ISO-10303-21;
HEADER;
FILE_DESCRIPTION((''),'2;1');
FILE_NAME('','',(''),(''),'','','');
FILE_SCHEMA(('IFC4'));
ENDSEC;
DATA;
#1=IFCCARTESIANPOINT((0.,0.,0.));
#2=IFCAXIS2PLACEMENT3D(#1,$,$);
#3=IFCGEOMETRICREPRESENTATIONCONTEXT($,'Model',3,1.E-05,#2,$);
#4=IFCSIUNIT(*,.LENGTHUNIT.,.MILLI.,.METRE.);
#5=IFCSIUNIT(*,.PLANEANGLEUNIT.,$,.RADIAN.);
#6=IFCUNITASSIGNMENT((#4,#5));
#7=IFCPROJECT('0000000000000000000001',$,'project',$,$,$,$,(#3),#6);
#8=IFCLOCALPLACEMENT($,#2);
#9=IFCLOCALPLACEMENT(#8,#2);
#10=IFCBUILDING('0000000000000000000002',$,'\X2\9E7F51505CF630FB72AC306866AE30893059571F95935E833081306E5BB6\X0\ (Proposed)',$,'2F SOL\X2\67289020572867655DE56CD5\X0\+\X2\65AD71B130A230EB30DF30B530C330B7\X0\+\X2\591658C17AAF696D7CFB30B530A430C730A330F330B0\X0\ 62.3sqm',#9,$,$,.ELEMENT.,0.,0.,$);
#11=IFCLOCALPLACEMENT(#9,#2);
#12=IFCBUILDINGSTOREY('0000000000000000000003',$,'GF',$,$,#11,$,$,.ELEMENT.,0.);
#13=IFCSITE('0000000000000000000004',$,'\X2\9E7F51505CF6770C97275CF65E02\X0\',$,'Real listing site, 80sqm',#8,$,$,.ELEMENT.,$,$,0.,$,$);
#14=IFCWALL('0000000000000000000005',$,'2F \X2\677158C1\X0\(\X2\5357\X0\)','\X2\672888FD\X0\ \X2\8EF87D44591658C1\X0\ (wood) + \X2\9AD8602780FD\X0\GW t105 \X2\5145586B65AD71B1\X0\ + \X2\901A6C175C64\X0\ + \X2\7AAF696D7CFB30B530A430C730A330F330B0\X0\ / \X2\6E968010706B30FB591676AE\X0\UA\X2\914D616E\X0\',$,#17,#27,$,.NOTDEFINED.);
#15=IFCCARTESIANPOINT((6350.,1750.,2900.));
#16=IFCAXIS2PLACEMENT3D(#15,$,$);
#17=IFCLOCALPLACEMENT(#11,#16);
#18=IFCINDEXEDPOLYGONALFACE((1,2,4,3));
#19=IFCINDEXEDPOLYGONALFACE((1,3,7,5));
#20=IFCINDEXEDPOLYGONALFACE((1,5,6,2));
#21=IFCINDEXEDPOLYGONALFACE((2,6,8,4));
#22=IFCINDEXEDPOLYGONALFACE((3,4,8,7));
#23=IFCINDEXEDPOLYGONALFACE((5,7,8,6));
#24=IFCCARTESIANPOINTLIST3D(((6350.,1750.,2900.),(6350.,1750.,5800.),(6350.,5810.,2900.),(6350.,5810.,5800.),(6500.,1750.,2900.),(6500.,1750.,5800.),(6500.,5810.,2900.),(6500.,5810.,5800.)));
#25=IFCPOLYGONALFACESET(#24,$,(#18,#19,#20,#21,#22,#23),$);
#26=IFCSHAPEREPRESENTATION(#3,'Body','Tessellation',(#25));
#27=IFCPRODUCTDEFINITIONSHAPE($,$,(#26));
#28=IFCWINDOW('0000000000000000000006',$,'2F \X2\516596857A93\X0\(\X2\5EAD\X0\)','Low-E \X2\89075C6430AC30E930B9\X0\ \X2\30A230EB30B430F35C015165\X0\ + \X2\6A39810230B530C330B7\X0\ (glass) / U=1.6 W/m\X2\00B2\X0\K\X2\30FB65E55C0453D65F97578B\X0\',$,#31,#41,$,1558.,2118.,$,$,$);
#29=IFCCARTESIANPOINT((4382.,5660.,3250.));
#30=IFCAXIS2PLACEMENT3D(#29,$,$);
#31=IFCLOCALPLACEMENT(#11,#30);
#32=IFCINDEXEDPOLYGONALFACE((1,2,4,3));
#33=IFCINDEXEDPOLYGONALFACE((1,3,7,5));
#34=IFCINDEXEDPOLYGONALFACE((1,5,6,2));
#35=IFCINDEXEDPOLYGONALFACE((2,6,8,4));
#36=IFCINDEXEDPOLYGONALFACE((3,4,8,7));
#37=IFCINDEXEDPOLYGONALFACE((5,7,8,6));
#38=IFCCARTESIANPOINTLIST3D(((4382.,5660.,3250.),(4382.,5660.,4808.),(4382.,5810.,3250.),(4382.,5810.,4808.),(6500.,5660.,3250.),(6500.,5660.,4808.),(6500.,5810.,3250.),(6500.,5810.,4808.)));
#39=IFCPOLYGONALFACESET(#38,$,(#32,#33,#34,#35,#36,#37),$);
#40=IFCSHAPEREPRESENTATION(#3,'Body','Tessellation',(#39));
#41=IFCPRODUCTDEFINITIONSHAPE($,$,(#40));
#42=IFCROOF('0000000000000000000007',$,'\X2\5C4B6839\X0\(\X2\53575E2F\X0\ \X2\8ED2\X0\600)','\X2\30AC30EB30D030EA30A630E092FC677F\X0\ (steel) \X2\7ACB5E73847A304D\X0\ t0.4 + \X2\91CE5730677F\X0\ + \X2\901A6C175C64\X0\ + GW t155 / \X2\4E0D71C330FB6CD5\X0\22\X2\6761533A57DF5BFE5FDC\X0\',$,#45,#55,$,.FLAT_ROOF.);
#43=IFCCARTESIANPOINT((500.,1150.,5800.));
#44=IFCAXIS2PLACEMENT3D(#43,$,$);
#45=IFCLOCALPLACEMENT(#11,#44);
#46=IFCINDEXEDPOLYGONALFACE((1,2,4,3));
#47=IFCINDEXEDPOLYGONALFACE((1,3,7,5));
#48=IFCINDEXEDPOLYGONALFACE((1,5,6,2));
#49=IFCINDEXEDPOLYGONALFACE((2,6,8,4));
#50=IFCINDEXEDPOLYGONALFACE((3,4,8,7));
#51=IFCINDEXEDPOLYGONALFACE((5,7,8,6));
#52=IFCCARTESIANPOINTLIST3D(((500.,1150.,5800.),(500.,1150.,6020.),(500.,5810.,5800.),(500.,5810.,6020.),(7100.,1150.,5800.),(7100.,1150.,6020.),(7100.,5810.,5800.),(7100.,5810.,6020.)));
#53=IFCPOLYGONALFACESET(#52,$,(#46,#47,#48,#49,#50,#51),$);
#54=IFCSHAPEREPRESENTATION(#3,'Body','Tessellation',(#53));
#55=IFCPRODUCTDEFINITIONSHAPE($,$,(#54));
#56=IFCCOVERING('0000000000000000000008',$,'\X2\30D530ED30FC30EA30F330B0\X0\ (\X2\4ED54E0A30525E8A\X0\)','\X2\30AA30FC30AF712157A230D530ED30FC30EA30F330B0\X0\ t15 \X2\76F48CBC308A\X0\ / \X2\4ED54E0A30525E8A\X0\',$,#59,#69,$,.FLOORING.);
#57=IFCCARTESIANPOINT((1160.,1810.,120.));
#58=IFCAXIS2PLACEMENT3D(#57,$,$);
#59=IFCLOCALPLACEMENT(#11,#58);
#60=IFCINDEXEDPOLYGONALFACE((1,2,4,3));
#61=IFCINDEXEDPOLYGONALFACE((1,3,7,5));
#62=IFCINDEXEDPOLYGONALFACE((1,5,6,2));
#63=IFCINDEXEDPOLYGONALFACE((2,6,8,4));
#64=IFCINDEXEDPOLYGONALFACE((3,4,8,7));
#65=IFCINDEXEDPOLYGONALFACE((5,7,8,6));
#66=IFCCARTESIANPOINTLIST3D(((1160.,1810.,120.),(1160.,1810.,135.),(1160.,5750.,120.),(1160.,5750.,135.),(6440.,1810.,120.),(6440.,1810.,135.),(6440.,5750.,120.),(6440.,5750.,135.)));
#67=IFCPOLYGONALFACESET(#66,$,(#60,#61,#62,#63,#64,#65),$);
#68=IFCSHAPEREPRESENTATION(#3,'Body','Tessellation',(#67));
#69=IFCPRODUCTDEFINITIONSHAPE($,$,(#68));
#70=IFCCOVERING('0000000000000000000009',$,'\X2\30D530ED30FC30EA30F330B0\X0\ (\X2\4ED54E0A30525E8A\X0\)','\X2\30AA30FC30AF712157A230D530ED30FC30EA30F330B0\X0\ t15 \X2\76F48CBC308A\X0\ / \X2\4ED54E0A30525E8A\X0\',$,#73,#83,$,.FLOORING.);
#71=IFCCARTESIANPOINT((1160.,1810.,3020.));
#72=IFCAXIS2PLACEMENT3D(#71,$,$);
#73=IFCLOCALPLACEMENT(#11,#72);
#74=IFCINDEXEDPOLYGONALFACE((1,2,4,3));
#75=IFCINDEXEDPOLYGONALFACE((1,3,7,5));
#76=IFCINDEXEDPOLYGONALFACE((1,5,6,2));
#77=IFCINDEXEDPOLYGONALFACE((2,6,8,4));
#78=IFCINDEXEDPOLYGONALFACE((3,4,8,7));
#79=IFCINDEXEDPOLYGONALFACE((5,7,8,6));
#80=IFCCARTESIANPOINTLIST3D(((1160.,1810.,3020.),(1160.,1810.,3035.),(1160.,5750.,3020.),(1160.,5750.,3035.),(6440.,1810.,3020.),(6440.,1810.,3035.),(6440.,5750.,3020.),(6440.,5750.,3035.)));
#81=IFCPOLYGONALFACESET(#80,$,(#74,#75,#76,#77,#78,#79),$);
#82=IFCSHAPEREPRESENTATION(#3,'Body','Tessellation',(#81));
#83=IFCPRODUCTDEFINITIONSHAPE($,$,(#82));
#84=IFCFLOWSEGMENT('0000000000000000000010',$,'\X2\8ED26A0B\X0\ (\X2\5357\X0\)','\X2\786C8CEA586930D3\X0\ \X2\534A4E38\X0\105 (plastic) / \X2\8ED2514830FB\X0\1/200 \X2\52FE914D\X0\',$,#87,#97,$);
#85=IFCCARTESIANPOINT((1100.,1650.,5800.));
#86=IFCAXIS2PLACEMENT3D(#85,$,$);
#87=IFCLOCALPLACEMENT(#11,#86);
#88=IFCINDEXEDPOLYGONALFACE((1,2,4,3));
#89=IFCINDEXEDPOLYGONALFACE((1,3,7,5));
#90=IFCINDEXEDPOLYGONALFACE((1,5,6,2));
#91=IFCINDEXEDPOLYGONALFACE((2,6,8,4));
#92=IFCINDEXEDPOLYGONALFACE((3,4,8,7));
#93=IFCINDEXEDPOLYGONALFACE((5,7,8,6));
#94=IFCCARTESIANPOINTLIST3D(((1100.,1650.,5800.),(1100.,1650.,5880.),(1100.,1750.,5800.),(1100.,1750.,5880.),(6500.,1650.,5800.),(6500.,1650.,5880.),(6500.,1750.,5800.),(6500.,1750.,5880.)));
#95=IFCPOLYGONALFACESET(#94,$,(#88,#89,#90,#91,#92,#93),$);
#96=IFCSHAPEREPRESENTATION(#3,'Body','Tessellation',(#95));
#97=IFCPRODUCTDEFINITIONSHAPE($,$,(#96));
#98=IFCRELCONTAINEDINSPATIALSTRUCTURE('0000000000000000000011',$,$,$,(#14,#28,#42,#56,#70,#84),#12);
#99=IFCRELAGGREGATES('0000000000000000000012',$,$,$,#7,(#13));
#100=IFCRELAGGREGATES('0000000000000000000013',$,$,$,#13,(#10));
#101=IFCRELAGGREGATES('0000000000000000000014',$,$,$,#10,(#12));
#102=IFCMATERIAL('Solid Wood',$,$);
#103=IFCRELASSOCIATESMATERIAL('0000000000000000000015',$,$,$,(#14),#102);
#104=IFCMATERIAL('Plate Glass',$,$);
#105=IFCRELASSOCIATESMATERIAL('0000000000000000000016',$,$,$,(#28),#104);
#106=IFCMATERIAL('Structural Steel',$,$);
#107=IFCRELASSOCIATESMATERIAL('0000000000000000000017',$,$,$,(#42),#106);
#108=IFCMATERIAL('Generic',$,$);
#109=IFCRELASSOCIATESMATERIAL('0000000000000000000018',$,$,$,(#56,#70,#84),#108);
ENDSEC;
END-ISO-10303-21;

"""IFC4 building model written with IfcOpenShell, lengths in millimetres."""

from ifc_helpers import new_model, si_unit, frame, frame_2d, origin, place, context, project, spatial, rectangle, extrude, material, element, fill, save


model = new_model("IFC4")

# Units and contexts
model_context = context("Model", 3, precision=1e-05, world=origin())
ifc_project = project(units=[si_unit("LENGTHUNIT", "METRE", prefix="MILLI"), si_unit("PLANEANGLEUNIT", "RADIAN")], contexts=[model_context])

# Site, building, storey
site_placement = place(None, origin())
site = spatial("IfcSite", under=ifc_project, at=site_placement, Name="鹿児島県霧島市", ObjectType="Real listing site, 80sqm", CompositionType="ELEMENT", RefElevation=0.0)
building_placement = place(site_placement, origin())
building = spatial("IfcBuilding", under=site, at=building_placement, Name="鹿児島・犬と暮らす土間広めの家 (Proposed)", ObjectType="2F SOL木造在来工法+断熱アルミサッシ+外壁窯業系サイディング 62.3sqm", CompositionType="ELEMENT", ElevationOfRefHeight=0.0, ElevationOfTerrain=0.0)
storey_placement = place(building_placement, origin())
storey = spatial("IfcBuildingStorey", under=building, at=storey_placement, Name="GF", CompositionType="ELEMENT", Elevation=0.0)

# Shared definitions
ifc_material_1 = material(Name="Solid Wood")

# Wall, opening, window
ifc_material_2 = material(Name="Plate Glass")
wall_1_placement = place(storey_placement, frame((6350.0, 1750.0, 2900.0)))
wall_1 = element("IfcWall", 1, at=wall_1_placement, inside=storey, material=ifc_material_1, Name="2F 東壁(南)", Description="木製 軸組外壁 (wood) + 高性能GW t105 充填断熱 + 通気層 + 窯業系サイディング / 準耐火・外皮UA配慮", PredefinedType="NOTDEFINED", context=model_context, shape_type="SweptSolid", body=[
    extrude(rectangle(XDim=150.0, YDim=4060.0, at=frame_2d((75.0, 2030.0))), frame((6350.0, 1750.0, 2900.0)), (0.0, 0.0, 1.0), 2900.0),
])
opening_1_placement = place(storey_placement, frame((4382.0, 5660.0, 3250.0)))
opening_1 = element("IfcOpeningElement", 2, at=opening_1_placement, cuts=wall_1, PredefinedType="NOTDEFINED", context=model_context, shape_type="SweptSolid", body=[
    extrude(rectangle(XDim=2118.0, YDim=150.0, at=frame_2d((1059.0, 75.0))), frame((4382.0, 5660.0, 3250.0)), (0.0, 0.0, 1.0), 1558.0),
])
window_1_placement = place(storey_placement, frame((4382.0, 5660.0, 3250.0)))
window_1 = element("IfcWindow", 3, at=window_1_placement, inside=storey, material=ifc_material_2, Name="2F 入隅窓(庭)", Description="Low-E 複層ガラス アルゴン封入 + 樹脂サッシ (glass) / U=1.6 W/m²K・日射取得型", OverallHeight=1558.0, OverallWidth=2118.0, context=model_context, shape_type="SweptSolid", body=[
    extrude(rectangle(XDim=2118.0, YDim=150.0, at=frame_2d((1059.0, 75.0))), frame((4382.0, 5660.0, 3250.0)), (0.0, 0.0, 1.0), 1558.0),
])
fill(opening_1, window_1)

# Roof
ifc_material_3 = material(Name="Structural Steel")
for number, where, name in (
    (4, (500.0, 1150.0, 5800.0), "屋根(南帯 軒600)"),
):
    element("IfcRoof", number, at=place(storey_placement, frame(where)), inside=storey, material=ifc_material_3, Name=name, Description="ガルバリウム鋼板 (steel) 立平葺き t0.4 + 野地板 + 通気層 + GW t155 / 不燃・法22条区域対応", PredefinedType="FLAT_ROOF", context=model_context, shape_type="SweptSolid", body=[
        extrude(rectangle(XDim=6600.0, YDim=4660.0, at=frame_2d((3300.0, 2330.0))), frame((500.0, 1150.0, 5800.0)), (0.0, 0.0, 1.0), 220.0),
    ])

# Coverings
ifc_material_4 = material(Name="Generic")
covering_1_placement = place(storey_placement, frame((1160.0, 1810.0, 120.0)))
element("IfcCovering", 5, at=covering_1_placement, inside=storey, material=ifc_material_4, Name="フローリング (仕上げ床)", Description="オーク無垢フローリング t15 直貼り / 仕上げ床", PredefinedType="FLOORING", context=model_context, shape_type="SweptSolid", body=[
    extrude(rectangle(XDim=5280.0, YDim=3940.0, at=frame_2d((2640.0, 1970.0))), frame((1160.0, 1810.0, 120.0)), (0.0, 0.0, 1.0), 15.0),
])
covering_2_placement = place(storey_placement, frame((1160.0, 1810.0, 3020.0)))
element("IfcCovering", 6, at=covering_2_placement, inside=storey, material=ifc_material_4, Name="フローリング (仕上げ床)", Description="オーク無垢フローリング t15 直貼り / 仕上げ床", PredefinedType="FLOORING", context=model_context, shape_type="SweptSolid", body=[
    extrude(rectangle(XDim=5280.0, YDim=3940.0, at=frame_2d((2640.0, 1970.0))), frame((1160.0, 1810.0, 3020.0)), (0.0, 0.0, 1.0), 15.0),
])

# Flow segment
flow_segment_placement = place(storey_placement, frame((1100.0, 1650.0, 5800.0)))
element("IfcFlowSegment", 7, at=flow_segment_placement, inside=storey, material=ifc_material_4, Name="軒樋 (南)", Description="硬質塩ビ 半丸105 (plastic) / 軒先・1/200 勾配", context=model_context, shape_type="SweptSolid", body=[
    extrude(rectangle(XDim=5400.0, YDim=100.0, at=frame_2d((2700.0, 50.0))), frame((1100.0, 1650.0, 5800.0)), (0.0, 0.0, 1.0), 80.0),
])

save(model, "model.ifc")
